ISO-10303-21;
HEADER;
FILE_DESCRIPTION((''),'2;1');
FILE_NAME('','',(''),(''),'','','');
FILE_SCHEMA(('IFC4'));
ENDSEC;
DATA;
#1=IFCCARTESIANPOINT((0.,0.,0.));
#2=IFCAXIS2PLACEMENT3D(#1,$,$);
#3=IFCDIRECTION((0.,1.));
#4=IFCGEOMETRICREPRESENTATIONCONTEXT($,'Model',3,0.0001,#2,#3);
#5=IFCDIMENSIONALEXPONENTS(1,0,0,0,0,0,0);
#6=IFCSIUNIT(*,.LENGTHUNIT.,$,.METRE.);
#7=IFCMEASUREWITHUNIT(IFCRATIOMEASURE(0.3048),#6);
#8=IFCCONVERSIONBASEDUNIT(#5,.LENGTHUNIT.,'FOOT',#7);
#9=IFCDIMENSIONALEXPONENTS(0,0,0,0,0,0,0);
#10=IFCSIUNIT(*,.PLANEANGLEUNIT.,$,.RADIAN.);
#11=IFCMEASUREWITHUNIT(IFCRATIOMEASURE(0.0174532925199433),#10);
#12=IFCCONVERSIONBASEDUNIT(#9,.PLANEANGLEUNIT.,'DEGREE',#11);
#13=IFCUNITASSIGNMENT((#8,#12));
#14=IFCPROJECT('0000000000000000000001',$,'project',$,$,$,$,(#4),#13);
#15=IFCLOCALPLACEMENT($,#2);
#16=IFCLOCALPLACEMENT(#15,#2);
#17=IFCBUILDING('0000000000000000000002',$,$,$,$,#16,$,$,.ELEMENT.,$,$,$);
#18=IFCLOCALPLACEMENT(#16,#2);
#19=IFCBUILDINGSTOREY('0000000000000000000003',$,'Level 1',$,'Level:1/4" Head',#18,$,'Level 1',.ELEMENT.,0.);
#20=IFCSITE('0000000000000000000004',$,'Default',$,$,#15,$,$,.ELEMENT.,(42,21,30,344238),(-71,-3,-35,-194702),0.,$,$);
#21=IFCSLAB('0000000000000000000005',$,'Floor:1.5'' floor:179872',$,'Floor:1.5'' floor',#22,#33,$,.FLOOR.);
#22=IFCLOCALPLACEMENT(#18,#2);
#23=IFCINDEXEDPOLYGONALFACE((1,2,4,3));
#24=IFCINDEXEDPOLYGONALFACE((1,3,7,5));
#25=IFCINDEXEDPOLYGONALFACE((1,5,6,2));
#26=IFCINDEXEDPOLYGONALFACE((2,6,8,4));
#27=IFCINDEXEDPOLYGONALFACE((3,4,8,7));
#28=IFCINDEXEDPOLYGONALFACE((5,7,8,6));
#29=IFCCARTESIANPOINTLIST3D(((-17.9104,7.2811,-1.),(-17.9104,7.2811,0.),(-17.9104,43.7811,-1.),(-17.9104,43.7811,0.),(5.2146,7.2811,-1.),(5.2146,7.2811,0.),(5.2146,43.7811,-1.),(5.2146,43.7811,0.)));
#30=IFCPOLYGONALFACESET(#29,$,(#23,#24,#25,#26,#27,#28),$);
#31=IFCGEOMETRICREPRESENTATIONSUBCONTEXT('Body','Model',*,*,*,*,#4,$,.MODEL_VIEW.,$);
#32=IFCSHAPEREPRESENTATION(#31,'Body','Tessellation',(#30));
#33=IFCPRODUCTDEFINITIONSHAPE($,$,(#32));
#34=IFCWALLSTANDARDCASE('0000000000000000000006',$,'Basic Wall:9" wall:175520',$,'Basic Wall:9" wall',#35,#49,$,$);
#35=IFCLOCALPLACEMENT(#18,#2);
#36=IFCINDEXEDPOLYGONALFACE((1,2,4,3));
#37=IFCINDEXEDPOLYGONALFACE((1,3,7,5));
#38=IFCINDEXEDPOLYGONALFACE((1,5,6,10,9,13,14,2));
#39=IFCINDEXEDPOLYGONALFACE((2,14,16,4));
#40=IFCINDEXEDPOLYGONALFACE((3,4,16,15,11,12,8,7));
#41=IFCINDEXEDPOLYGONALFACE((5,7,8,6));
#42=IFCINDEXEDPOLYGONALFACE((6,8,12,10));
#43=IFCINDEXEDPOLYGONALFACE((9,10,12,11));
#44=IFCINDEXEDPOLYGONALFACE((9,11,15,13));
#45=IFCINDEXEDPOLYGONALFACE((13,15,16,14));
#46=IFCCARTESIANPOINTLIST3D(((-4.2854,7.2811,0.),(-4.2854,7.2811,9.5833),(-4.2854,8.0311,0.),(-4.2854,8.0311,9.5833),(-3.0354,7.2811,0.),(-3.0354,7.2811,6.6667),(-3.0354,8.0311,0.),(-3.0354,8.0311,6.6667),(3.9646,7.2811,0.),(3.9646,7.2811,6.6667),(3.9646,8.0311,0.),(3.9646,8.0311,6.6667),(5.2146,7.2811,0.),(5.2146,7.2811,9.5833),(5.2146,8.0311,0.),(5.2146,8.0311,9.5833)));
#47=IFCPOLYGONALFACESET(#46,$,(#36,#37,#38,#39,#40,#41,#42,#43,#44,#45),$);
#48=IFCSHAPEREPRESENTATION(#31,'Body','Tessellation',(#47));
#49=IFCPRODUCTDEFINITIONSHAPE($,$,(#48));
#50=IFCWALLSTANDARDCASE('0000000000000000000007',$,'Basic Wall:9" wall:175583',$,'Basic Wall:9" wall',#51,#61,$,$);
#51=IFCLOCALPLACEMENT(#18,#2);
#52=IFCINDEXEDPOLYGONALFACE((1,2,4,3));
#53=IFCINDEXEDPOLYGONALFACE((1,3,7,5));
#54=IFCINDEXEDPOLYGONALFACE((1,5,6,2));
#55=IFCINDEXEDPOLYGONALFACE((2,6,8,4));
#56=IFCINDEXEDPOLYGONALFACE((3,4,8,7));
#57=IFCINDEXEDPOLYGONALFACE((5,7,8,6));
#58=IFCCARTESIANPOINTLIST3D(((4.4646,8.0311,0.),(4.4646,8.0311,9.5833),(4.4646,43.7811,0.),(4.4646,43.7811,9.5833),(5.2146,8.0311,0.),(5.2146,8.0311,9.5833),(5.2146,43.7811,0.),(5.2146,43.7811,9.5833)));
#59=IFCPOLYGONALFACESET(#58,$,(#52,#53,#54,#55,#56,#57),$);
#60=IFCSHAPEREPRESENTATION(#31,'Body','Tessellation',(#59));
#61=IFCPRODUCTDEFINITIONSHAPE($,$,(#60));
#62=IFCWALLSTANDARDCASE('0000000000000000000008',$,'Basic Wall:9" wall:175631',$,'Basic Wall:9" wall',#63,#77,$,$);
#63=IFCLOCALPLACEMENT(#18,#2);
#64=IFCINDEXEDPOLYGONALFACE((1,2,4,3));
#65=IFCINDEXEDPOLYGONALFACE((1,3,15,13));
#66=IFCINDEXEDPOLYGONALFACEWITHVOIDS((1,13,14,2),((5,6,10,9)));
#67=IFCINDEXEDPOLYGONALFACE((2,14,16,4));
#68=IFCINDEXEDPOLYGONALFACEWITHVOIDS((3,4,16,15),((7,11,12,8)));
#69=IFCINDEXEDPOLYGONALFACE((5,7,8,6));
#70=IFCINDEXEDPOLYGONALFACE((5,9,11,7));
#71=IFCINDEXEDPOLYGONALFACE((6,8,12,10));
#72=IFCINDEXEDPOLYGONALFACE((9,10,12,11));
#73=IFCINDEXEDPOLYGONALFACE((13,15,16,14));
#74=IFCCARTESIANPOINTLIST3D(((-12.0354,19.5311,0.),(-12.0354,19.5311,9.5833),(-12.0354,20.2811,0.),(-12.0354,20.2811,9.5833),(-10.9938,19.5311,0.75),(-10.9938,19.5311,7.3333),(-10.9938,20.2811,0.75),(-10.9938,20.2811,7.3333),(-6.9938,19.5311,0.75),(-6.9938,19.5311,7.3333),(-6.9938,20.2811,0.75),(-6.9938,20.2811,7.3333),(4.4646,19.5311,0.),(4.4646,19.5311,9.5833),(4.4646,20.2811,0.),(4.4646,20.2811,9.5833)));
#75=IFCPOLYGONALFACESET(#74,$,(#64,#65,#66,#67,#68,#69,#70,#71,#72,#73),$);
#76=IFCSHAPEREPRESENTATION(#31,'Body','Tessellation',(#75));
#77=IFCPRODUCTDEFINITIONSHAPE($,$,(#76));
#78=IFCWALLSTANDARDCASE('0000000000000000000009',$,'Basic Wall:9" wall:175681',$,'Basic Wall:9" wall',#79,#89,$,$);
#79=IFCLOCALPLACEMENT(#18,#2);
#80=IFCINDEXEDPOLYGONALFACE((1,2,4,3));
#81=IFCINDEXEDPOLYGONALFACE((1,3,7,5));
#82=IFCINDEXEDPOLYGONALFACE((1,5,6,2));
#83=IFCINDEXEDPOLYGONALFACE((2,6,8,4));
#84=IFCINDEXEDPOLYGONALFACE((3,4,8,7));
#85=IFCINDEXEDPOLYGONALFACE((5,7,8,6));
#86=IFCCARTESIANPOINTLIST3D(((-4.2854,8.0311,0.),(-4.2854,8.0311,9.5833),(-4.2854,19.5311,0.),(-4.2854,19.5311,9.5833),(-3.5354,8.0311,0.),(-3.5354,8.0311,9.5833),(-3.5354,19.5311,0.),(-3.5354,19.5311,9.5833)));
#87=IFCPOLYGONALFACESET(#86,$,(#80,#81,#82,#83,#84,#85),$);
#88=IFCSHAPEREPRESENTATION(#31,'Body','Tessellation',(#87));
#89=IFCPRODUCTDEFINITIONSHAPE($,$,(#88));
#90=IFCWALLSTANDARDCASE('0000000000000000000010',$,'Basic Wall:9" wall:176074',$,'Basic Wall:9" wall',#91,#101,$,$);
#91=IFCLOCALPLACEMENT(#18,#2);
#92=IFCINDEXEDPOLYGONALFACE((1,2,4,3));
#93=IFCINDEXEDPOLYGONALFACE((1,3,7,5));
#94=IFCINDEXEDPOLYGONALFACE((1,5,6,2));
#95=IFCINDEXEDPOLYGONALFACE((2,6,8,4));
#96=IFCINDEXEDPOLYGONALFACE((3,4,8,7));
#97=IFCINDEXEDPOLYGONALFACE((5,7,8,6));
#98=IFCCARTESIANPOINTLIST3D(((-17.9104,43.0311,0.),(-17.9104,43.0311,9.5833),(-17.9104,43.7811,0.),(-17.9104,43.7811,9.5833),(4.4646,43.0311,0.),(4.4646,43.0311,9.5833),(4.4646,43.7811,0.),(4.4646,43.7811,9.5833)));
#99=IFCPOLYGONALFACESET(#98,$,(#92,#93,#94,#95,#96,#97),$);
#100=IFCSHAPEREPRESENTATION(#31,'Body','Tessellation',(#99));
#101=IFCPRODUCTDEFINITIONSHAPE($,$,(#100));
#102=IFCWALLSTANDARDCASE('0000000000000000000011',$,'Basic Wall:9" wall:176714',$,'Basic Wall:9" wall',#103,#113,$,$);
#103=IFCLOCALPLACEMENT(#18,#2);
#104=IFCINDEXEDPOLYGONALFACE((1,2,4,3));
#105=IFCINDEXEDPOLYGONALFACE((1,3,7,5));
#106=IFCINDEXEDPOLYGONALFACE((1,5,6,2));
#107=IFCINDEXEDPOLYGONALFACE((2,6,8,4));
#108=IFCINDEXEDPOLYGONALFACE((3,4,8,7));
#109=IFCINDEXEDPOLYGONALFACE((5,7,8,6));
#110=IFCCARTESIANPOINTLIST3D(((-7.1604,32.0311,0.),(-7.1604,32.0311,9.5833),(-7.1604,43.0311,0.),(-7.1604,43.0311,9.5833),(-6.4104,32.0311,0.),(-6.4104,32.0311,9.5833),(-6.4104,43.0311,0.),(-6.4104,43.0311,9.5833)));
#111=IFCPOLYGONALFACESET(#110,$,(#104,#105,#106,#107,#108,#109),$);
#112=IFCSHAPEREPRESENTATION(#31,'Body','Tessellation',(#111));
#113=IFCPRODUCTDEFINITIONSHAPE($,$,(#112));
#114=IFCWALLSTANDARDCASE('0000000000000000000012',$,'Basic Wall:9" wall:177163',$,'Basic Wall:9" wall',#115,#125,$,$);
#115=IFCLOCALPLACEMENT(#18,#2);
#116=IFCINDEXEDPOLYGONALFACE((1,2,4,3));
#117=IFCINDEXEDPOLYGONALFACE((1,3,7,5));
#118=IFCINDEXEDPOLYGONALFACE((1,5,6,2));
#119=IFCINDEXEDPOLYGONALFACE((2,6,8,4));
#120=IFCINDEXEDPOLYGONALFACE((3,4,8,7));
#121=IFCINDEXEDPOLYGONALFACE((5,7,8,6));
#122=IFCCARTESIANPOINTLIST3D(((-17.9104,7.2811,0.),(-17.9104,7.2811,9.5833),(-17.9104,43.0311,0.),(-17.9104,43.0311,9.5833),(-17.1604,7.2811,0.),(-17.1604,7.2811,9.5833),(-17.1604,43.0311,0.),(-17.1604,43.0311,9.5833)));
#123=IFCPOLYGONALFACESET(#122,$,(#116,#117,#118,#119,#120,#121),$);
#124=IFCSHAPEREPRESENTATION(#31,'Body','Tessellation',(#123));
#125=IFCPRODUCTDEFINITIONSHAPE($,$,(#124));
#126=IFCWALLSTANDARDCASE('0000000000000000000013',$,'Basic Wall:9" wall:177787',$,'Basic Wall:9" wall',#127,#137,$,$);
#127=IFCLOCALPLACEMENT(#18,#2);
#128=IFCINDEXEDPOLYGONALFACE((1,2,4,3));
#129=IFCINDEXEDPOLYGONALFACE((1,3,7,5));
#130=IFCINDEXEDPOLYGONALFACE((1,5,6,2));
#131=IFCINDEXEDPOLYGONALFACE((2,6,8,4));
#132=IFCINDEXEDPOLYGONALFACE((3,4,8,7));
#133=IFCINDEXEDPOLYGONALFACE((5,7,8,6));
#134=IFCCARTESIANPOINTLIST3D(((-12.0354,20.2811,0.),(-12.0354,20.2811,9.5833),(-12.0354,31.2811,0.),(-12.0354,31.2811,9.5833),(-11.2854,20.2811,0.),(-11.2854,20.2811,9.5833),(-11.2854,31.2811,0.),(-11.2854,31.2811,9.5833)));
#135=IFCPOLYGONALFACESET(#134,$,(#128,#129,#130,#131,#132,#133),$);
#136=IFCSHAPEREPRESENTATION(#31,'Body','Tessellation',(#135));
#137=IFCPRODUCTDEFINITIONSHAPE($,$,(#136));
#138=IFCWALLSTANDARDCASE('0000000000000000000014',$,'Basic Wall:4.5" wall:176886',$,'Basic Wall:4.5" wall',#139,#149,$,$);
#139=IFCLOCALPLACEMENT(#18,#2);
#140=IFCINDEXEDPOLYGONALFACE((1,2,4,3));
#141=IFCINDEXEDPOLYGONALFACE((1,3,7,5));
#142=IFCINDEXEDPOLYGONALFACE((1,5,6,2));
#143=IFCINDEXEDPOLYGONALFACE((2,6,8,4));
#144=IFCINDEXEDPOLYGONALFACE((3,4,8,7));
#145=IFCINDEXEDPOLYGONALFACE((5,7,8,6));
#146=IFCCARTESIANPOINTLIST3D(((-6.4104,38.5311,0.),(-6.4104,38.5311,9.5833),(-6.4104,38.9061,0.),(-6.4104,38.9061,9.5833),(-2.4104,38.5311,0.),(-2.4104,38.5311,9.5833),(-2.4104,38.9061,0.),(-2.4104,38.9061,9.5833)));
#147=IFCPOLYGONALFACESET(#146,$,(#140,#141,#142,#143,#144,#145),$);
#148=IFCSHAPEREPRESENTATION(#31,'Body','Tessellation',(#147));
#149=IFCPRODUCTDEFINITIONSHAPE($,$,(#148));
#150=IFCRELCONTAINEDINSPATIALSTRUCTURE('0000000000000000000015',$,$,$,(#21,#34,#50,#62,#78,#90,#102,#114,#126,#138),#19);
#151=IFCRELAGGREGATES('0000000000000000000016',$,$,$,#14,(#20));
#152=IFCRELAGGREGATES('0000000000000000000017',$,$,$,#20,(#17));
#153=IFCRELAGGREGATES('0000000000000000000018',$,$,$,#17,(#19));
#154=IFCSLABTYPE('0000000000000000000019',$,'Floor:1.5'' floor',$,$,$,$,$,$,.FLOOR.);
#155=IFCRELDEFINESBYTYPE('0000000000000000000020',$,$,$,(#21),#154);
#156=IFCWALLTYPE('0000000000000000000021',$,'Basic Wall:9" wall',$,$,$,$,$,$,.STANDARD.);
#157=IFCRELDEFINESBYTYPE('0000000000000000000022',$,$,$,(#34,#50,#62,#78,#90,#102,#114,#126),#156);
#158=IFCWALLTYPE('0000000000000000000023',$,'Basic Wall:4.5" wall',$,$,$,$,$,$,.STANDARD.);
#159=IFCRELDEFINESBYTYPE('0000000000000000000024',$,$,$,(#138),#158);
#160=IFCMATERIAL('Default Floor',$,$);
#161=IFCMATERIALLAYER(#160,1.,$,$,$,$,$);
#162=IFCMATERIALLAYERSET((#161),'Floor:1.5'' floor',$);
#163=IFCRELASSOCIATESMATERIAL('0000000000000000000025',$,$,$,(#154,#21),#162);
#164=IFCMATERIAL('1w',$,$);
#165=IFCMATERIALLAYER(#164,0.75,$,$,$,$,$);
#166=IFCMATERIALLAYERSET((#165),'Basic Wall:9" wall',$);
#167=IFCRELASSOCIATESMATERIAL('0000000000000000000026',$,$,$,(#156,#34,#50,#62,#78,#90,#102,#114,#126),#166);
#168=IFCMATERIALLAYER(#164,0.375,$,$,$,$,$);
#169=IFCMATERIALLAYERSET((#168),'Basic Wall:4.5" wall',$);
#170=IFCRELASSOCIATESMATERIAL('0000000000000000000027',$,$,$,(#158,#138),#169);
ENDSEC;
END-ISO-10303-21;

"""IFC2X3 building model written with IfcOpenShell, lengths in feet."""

from ifc_helpers import new_model, entity, si_unit, converted_unit, direction, frame, frame_2d, origin, origin_2d_with_axis, place, context, subcontext, project, spatial, polyline, rectangle, extrude, clip, bounded_halfspace, material, layer, layer_set, layer_usage, type_object, element, save


model = new_model("IFC2X3")

# Units and contexts
model_context = context("Model", 3, precision=0.0001, world=origin(), true_north=direction((0.0, 1.0)))
body_context = subcontext(model_context, "Body", "Model", "MODEL_VIEW")
ifc_project = project(units=[converted_unit("LENGTHUNIT", "FOOT", entity("IfcRatioMeasure", 0.3048), si_unit("LENGTHUNIT", "METRE"), dimensions=[1, 0, 0, 0, 0, 0, 0]), converted_unit("PLANEANGLEUNIT", "DEGREE", entity("IfcRatioMeasure", 0.0174532925199433), si_unit("PLANEANGLEUNIT", "RADIAN"), dimensions=[0, 0, 0, 0, 0, 0, 0])], contexts=[model_context])

# Site, building, storey
site_placement = place(None, origin())
site = spatial("IfcSite", under=ifc_project, at=site_placement, Name="Default", CompositionType="ELEMENT", RefLatitude=(42, 21, 30, 344238), RefLongitude=(-71, -3, -35, -194702), RefElevation=0.0)
building_placement = place(site_placement, origin())
building = spatial("IfcBuilding", under=site, at=building_placement, CompositionType="ELEMENT")
storey_placement = place(building_placement, origin())
storey = spatial("IfcBuildingStorey", under=building, at=storey_placement, Name="Level 1", ObjectType="Level:1/4\" Head", LongName="Level 1", CompositionType="ELEMENT", Elevation=0.0)

# Slab
ifc_material_1 = material(Name="Default Floor")
ifc_layer_1 = layer(ifc_material_1, 1.0)
ifc_layer_set_1 = layer_set([ifc_layer_1], Name="Floor:1.5' floor")
ifc_layer_usage_1 = layer_usage(ifc_layer_set_1, "AXIS3", "POSITIVE", 0.0)
slab_type = type_object("IfcSlabType", Name="Floor:1.5' floor", PredefinedType="FLOOR", material=ifc_layer_set_1)
slab_placement = place(storey_placement, origin())
element("IfcSlab", 1, at=slab_placement, inside=storey, type_object=slab_type, material=ifc_layer_usage_1, Name="Floor:1.5' floor:179872", ObjectType="Floor:1.5' floor", PredefinedType="FLOOR", context=body_context, shape_type="SweptSolid", body=[
    extrude(rectangle(XDim=36.5, YDim=23.125, at=origin_2d_with_axis()), frame((-6.3479, 25.5311, 0.0), z_axis=(0.0, 0.0, -1.0), x_axis=(0.0, 1.0, 0.0)), (0.0, 0.0, 1.0), 1.0),
])

# Wall, opening
ifc_material_2 = material(Name="1w")
ifc_layer_2 = layer(ifc_material_2, 0.75)
ifc_layer_set_2 = layer_set([ifc_layer_2], Name="Basic Wall:9\" wall")
ifc_layer_usage_2 = layer_usage(ifc_layer_set_2, "AXIS2", "NEGATIVE", 0.375)
wall_type_1 = type_object("IfcWallType", Name="Basic Wall:9\" wall", PredefinedType="STANDARD", material=ifc_layer_set_2)
wall_1_placement = place(storey_placement, frame((-4.2854, 7.6561, 0.0)))
wall_1 = element("IfcWallStandardCase", 2, at=wall_1_placement, inside=storey, type_object=wall_type_1, material=ifc_layer_usage_2, Name="Basic Wall:9\" wall:175520", ObjectType="Basic Wall:9\" wall", context=body_context, shape_type="Clipping", body=[
    clip(extrude(rectangle(XDim=9.5, YDim=0.75, at=frame_2d((4.75, 0.0), x_axis=(-1.0, 0.0))), origin(), (0.0, 0.0, 1.0), 9.5833), bounded_halfspace(frame((0.0, -0.375, 9.5833), z_axis=(0.0, 0.0, -1.0), x_axis=(0.0, -1.0, 0.0)), True, frame((0.0, -0.375, 9.5833)), polyline([(0.0, 0.0), (9.5, 0.0), (9.5, 0.75), (8.75, 0.75), (0.75, 0.75), (0.0, 0.75), (0.0, 0.0)]))),
])
opening_1_placement = place(wall_1_placement, origin())
element("IfcOpeningElement", 3, at=opening_1_placement, cuts=wall_1, ObjectType="Opening", context=body_context, shape_type="SweptSolid", body=[
    extrude(rectangle(XDim=6.6667, YDim=7.0, at=frame_2d((0.0, 0.0), x_axis=(0.0, 1.0))), frame((4.75, 0.375, 3.3333), z_axis=(0.0, -1.0, 0.0), x_axis=(1.0, 0.0, 0.0)), (0.0, 0.0, 1.0), 0.75),
])

# Wall
ifc_layer_usage_3 = layer_usage(ifc_layer_set_2, "AXIS2", "NEGATIVE", 0.375)
wall_2_placement = place(storey_placement, frame((4.8396, 8.0311, 0.0), z_axis=(0.0, 0.0, 1.0), x_axis=(0.0, 1.0, 0.0)))
element("IfcWallStandardCase", 4, at=wall_2_placement, inside=storey, type_object=wall_type_1, material=ifc_layer_usage_3, Name="Basic Wall:9\" wall:175583", ObjectType="Basic Wall:9\" wall", context=body_context, shape_type="Clipping", body=[
    clip(extrude(rectangle(XDim=35.75, YDim=0.75, at=frame_2d((17.875, 0.0), x_axis=(-1.0, 0.0))), origin(), (0.0, 0.0, 1.0), 9.5833), bounded_halfspace(frame((0.0, -0.375, 9.5833), z_axis=(0.0, 0.0, -1.0), x_axis=(-1.0, 0.0, 0.0)), True, frame((0.0, -0.375, 9.5833)), polyline([(0.0, 0.0), (35.75, 0.0), (35.75, 0.75), (35.0, 0.75), (24.0, 0.75), (23.25, 0.75), (12.25, 0.75), (11.5, 0.75), (0.0, 0.75), (0.0, 0.0)]))),
])

# Wall, opening
ifc_layer_usage_4 = layer_usage(ifc_layer_set_2, "AXIS2", "NEGATIVE", 0.375)
wall_3_placement = place(storey_placement, frame((4.4646, 19.9061, 0.0), z_axis=(0.0, 0.0, 1.0), x_axis=(-1.0, 0.0, 0.0)))
wall_3 = element("IfcWallStandardCase", 5, at=wall_3_placement, inside=storey, type_object=wall_type_1, material=ifc_layer_usage_4, Name="Basic Wall:9\" wall:175631", ObjectType="Basic Wall:9\" wall", context=body_context, shape_type="Clipping", body=[
    clip(extrude(rectangle(XDim=16.5, YDim=0.75, at=frame_2d((8.25, 0.0), x_axis=(-1.0, 0.0))), origin(), (0.0, 0.0, 1.0), 9.5833), bounded_halfspace(frame((0.0, -0.375, 9.5833), z_axis=(0.0, 0.0, -1.0), x_axis=(0.0, 1.0, 0.0)), True, frame((0.0, -0.375, 9.5833)), polyline([(0.0, 0.0), (15.75, 0.0), (16.5, 0.0), (16.5, 0.75), (8.75, 0.75), (8.0, 0.75), (0.0, 0.75), (0.0, 0.0)]))),
])
opening_2_placement = place(wall_3_placement, origin())
element("IfcOpeningElement", 6, at=opening_2_placement, cuts=wall_3, ObjectType="Opening", context=body_context, shape_type="SweptSolid", body=[
    extrude(rectangle(XDim=6.5833, YDim=4.0, at=frame_2d((0.0, 0.0), x_axis=(0.0, 1.0))), frame((13.4583, 0.375, 4.0417), z_axis=(0.0, -1.0, 0.0), x_axis=(-1.0, 0.0, 0.0)), (0.0, 0.0, 1.0), 0.75),
])

# Walls
ifc_layer_usage_5 = layer_usage(ifc_layer_set_2, "AXIS2", "NEGATIVE", 0.375)
wall_4_placement = place(storey_placement, frame((-3.9104, 19.5311, 0.0), z_axis=(0.0, 0.0, 1.0), x_axis=(0.0, -1.0, 0.0)))
element("IfcWallStandardCase", 7, at=wall_4_placement, inside=storey, type_object=wall_type_1, material=ifc_layer_usage_5, Name="Basic Wall:9\" wall:175681", ObjectType="Basic Wall:9\" wall", context=body_context, shape_type="Clipping", body=[
    clip(extrude(rectangle(XDim=11.5, YDim=0.75, at=frame_2d((5.75, 0.0), x_axis=(-1.0, 0.0))), origin(), (0.0, 0.0, 1.0), 9.5833), bounded_halfspace(frame((0.0, -0.375, 9.5833), z_axis=(0.0, 0.0, -1.0), x_axis=(1.0, 0.0, 0.0)), True, frame((0.0, -0.375, 9.5833)), polyline([(0.0, 0.0), (11.5, 0.0), (11.5, 0.75), (0.0, 0.75), (0.0, 0.0)]))),
])
ifc_layer_usage_6 = layer_usage(ifc_layer_set_2, "AXIS2", "NEGATIVE", 0.375)
wall_5_placement = place(storey_placement, frame((4.4646, 43.4061, 0.0), z_axis=(0.0, 0.0, 1.0), x_axis=(-1.0, 0.0, 0.0)))
element("IfcWallStandardCase", 8, at=wall_5_placement, inside=storey, type_object=wall_type_1, material=ifc_layer_usage_6, Name="Basic Wall:9\" wall:176074", ObjectType="Basic Wall:9\" wall", context=body_context, shape_type="Clipping", body=[
    clip(extrude(rectangle(XDim=22.375, YDim=0.75, at=frame_2d((11.1875, 0.0), x_axis=(-1.0, 0.0))), origin(), (0.0, 0.0, 1.0), 9.5833), bounded_halfspace(frame((0.0, -0.375, 9.5833), z_axis=(0.0, 0.0, -1.0), x_axis=(0.0, 1.0, 0.0)), True, frame((0.0, -0.375, 9.5833)), polyline([(0.0, 0.0), (22.375, 0.0), (22.375, 0.75), (21.625, 0.75), (11.625, 0.75), (10.875, 0.75), (6.875, 0.75), (6.5, 0.75), (0.0, 0.75), (0.0, 0.0)]))),
])
ifc_layer_usage_7 = layer_usage(ifc_layer_set_2, "AXIS2", "NEGATIVE", 0.375)
wall_6_placement = place(storey_placement, frame((-6.7854, 43.0311, 0.0), z_axis=(0.0, 0.0, 1.0), x_axis=(0.0, -1.0, 0.0)))
element("IfcWallStandardCase", 9, at=wall_6_placement, inside=storey, type_object=wall_type_1, material=ifc_layer_usage_7, Name="Basic Wall:9\" wall:176714", ObjectType="Basic Wall:9\" wall", context=body_context, shape_type="Clipping", body=[
    clip(extrude(rectangle(XDim=11.0, YDim=0.75, at=frame_2d((5.5, 0.0), x_axis=(-1.0, 0.0))), origin(), (0.0, 0.0, 1.0), 9.5833), bounded_halfspace(frame((0.0, -0.375, 9.5833), z_axis=(0.0, 0.0, -1.0), x_axis=(1.0, 0.0, 0.0)), True, frame((0.0, -0.375, 9.5833)), polyline([(0.0, 0.0), (11.0, 0.0), (11.0, 0.75), (4.5, 0.75), (4.125, 0.75), (0.0, 0.75), (0.0, 0.0)]))),
])
ifc_layer_usage_8 = layer_usage(ifc_layer_set_2, "AXIS2", "NEGATIVE", 0.375)
wall_7_placement = place(storey_placement, frame((-17.5354, 43.0311, 0.0), z_axis=(0.0, 0.0, 1.0), x_axis=(0.0, -1.0, 0.0)))
element("IfcWallStandardCase", 10, at=wall_7_placement, inside=storey, type_object=wall_type_1, material=ifc_layer_usage_8, Name="Basic Wall:9\" wall:177163", ObjectType="Basic Wall:9\" wall", context=body_context, shape_type="Clipping", body=[
    clip(extrude(rectangle(XDim=35.75, YDim=0.75, at=frame_2d((17.875, 0.0), x_axis=(-1.0, 0.0))), origin(), (0.0, 0.0, 1.0), 9.5833), bounded_halfspace(frame((0.0, -0.375, 9.5833), z_axis=(0.0, 0.0, -1.0), x_axis=(1.0, 0.0, 0.0)), True, frame((0.0, -0.375, 9.5833)), polyline([(0.0, 0.0), (35.75, 0.0), (35.75, 0.75), (14.25, 0.75), (11.75, 0.75), (11.0, 0.75), (0.0, 0.75), (0.0, 0.0)]))),
])
ifc_layer_usage_9 = layer_usage(ifc_layer_set_2, "AXIS2", "POSITIVE", -0.375)
wall_8_placement = place(storey_placement, frame((-11.6604, 20.2811, 0.0), z_axis=(0.0, 0.0, 1.0), x_axis=(0.0, 1.0, 0.0)))
element("IfcWallStandardCase", 11, at=wall_8_placement, inside=storey, type_object=wall_type_1, material=ifc_layer_usage_9, Name="Basic Wall:9\" wall:177787", ObjectType="Basic Wall:9\" wall", context=body_context, shape_type="Clipping", body=[
    clip(extrude(rectangle(XDim=11.0, YDim=0.75, at=frame_2d((5.5, 0.0), x_axis=(-1.0, 0.0))), origin(), (0.0, 0.0, 1.0), 9.5833), bounded_halfspace(frame((0.0, -0.375, 9.5833), z_axis=(0.0, 0.0, -1.0), x_axis=(-1.0, 0.0, 0.0)), True, frame((0.0, -0.375, 9.5833)), polyline([(0.0, 0.0), (11.0, 0.0), (11.0, 0.75), (1.0625, 0.75), (0.0, 0.75), (0.0, 0.0)]))),
])

# Shared definitions
ifc_layer_3 = layer(ifc_material_2, 0.375)
ifc_layer_set_3 = layer_set([ifc_layer_3], Name="Basic Wall:4.5\" wall")
wall_type_2 = type_object("IfcWallType", Name="Basic Wall:4.5\" wall", PredefinedType="STANDARD", material=ifc_layer_set_3)

# Wall
ifc_layer_usage_10 = layer_usage(ifc_layer_set_3, "AXIS2", "NEGATIVE", 0.1875)
wall_9_placement = place(storey_placement, frame((-2.4104, 38.7186, 0.0), z_axis=(0.0, 0.0, 1.0), x_axis=(-1.0, 0.0, 0.0)))
element("IfcWallStandardCase", 12, at=wall_9_placement, inside=storey, type_object=wall_type_2, material=ifc_layer_usage_10, Name="Basic Wall:4.5\" wall:176886", ObjectType="Basic Wall:4.5\" wall", context=body_context, shape_type="Clipping", body=[
    clip(extrude(rectangle(XDim=4.0, YDim=0.375, at=frame_2d((2.0, 0.0), x_axis=(-1.0, 0.0))), origin(), (0.0, 0.0, 1.0), 9.5833), bounded_halfspace(frame((0.0, -0.1875, 9.5833), z_axis=(0.0, 0.0, -1.0), x_axis=(0.0, 1.0, 0.0)), True, frame((0.0, -0.1875, 9.5833)), polyline([(0.0, 0.0), (4.0, 0.0), (4.0, 0.375), (0.0, 0.375), (0.0, 0.0)]))),
])

save(model, "model.ifc")
